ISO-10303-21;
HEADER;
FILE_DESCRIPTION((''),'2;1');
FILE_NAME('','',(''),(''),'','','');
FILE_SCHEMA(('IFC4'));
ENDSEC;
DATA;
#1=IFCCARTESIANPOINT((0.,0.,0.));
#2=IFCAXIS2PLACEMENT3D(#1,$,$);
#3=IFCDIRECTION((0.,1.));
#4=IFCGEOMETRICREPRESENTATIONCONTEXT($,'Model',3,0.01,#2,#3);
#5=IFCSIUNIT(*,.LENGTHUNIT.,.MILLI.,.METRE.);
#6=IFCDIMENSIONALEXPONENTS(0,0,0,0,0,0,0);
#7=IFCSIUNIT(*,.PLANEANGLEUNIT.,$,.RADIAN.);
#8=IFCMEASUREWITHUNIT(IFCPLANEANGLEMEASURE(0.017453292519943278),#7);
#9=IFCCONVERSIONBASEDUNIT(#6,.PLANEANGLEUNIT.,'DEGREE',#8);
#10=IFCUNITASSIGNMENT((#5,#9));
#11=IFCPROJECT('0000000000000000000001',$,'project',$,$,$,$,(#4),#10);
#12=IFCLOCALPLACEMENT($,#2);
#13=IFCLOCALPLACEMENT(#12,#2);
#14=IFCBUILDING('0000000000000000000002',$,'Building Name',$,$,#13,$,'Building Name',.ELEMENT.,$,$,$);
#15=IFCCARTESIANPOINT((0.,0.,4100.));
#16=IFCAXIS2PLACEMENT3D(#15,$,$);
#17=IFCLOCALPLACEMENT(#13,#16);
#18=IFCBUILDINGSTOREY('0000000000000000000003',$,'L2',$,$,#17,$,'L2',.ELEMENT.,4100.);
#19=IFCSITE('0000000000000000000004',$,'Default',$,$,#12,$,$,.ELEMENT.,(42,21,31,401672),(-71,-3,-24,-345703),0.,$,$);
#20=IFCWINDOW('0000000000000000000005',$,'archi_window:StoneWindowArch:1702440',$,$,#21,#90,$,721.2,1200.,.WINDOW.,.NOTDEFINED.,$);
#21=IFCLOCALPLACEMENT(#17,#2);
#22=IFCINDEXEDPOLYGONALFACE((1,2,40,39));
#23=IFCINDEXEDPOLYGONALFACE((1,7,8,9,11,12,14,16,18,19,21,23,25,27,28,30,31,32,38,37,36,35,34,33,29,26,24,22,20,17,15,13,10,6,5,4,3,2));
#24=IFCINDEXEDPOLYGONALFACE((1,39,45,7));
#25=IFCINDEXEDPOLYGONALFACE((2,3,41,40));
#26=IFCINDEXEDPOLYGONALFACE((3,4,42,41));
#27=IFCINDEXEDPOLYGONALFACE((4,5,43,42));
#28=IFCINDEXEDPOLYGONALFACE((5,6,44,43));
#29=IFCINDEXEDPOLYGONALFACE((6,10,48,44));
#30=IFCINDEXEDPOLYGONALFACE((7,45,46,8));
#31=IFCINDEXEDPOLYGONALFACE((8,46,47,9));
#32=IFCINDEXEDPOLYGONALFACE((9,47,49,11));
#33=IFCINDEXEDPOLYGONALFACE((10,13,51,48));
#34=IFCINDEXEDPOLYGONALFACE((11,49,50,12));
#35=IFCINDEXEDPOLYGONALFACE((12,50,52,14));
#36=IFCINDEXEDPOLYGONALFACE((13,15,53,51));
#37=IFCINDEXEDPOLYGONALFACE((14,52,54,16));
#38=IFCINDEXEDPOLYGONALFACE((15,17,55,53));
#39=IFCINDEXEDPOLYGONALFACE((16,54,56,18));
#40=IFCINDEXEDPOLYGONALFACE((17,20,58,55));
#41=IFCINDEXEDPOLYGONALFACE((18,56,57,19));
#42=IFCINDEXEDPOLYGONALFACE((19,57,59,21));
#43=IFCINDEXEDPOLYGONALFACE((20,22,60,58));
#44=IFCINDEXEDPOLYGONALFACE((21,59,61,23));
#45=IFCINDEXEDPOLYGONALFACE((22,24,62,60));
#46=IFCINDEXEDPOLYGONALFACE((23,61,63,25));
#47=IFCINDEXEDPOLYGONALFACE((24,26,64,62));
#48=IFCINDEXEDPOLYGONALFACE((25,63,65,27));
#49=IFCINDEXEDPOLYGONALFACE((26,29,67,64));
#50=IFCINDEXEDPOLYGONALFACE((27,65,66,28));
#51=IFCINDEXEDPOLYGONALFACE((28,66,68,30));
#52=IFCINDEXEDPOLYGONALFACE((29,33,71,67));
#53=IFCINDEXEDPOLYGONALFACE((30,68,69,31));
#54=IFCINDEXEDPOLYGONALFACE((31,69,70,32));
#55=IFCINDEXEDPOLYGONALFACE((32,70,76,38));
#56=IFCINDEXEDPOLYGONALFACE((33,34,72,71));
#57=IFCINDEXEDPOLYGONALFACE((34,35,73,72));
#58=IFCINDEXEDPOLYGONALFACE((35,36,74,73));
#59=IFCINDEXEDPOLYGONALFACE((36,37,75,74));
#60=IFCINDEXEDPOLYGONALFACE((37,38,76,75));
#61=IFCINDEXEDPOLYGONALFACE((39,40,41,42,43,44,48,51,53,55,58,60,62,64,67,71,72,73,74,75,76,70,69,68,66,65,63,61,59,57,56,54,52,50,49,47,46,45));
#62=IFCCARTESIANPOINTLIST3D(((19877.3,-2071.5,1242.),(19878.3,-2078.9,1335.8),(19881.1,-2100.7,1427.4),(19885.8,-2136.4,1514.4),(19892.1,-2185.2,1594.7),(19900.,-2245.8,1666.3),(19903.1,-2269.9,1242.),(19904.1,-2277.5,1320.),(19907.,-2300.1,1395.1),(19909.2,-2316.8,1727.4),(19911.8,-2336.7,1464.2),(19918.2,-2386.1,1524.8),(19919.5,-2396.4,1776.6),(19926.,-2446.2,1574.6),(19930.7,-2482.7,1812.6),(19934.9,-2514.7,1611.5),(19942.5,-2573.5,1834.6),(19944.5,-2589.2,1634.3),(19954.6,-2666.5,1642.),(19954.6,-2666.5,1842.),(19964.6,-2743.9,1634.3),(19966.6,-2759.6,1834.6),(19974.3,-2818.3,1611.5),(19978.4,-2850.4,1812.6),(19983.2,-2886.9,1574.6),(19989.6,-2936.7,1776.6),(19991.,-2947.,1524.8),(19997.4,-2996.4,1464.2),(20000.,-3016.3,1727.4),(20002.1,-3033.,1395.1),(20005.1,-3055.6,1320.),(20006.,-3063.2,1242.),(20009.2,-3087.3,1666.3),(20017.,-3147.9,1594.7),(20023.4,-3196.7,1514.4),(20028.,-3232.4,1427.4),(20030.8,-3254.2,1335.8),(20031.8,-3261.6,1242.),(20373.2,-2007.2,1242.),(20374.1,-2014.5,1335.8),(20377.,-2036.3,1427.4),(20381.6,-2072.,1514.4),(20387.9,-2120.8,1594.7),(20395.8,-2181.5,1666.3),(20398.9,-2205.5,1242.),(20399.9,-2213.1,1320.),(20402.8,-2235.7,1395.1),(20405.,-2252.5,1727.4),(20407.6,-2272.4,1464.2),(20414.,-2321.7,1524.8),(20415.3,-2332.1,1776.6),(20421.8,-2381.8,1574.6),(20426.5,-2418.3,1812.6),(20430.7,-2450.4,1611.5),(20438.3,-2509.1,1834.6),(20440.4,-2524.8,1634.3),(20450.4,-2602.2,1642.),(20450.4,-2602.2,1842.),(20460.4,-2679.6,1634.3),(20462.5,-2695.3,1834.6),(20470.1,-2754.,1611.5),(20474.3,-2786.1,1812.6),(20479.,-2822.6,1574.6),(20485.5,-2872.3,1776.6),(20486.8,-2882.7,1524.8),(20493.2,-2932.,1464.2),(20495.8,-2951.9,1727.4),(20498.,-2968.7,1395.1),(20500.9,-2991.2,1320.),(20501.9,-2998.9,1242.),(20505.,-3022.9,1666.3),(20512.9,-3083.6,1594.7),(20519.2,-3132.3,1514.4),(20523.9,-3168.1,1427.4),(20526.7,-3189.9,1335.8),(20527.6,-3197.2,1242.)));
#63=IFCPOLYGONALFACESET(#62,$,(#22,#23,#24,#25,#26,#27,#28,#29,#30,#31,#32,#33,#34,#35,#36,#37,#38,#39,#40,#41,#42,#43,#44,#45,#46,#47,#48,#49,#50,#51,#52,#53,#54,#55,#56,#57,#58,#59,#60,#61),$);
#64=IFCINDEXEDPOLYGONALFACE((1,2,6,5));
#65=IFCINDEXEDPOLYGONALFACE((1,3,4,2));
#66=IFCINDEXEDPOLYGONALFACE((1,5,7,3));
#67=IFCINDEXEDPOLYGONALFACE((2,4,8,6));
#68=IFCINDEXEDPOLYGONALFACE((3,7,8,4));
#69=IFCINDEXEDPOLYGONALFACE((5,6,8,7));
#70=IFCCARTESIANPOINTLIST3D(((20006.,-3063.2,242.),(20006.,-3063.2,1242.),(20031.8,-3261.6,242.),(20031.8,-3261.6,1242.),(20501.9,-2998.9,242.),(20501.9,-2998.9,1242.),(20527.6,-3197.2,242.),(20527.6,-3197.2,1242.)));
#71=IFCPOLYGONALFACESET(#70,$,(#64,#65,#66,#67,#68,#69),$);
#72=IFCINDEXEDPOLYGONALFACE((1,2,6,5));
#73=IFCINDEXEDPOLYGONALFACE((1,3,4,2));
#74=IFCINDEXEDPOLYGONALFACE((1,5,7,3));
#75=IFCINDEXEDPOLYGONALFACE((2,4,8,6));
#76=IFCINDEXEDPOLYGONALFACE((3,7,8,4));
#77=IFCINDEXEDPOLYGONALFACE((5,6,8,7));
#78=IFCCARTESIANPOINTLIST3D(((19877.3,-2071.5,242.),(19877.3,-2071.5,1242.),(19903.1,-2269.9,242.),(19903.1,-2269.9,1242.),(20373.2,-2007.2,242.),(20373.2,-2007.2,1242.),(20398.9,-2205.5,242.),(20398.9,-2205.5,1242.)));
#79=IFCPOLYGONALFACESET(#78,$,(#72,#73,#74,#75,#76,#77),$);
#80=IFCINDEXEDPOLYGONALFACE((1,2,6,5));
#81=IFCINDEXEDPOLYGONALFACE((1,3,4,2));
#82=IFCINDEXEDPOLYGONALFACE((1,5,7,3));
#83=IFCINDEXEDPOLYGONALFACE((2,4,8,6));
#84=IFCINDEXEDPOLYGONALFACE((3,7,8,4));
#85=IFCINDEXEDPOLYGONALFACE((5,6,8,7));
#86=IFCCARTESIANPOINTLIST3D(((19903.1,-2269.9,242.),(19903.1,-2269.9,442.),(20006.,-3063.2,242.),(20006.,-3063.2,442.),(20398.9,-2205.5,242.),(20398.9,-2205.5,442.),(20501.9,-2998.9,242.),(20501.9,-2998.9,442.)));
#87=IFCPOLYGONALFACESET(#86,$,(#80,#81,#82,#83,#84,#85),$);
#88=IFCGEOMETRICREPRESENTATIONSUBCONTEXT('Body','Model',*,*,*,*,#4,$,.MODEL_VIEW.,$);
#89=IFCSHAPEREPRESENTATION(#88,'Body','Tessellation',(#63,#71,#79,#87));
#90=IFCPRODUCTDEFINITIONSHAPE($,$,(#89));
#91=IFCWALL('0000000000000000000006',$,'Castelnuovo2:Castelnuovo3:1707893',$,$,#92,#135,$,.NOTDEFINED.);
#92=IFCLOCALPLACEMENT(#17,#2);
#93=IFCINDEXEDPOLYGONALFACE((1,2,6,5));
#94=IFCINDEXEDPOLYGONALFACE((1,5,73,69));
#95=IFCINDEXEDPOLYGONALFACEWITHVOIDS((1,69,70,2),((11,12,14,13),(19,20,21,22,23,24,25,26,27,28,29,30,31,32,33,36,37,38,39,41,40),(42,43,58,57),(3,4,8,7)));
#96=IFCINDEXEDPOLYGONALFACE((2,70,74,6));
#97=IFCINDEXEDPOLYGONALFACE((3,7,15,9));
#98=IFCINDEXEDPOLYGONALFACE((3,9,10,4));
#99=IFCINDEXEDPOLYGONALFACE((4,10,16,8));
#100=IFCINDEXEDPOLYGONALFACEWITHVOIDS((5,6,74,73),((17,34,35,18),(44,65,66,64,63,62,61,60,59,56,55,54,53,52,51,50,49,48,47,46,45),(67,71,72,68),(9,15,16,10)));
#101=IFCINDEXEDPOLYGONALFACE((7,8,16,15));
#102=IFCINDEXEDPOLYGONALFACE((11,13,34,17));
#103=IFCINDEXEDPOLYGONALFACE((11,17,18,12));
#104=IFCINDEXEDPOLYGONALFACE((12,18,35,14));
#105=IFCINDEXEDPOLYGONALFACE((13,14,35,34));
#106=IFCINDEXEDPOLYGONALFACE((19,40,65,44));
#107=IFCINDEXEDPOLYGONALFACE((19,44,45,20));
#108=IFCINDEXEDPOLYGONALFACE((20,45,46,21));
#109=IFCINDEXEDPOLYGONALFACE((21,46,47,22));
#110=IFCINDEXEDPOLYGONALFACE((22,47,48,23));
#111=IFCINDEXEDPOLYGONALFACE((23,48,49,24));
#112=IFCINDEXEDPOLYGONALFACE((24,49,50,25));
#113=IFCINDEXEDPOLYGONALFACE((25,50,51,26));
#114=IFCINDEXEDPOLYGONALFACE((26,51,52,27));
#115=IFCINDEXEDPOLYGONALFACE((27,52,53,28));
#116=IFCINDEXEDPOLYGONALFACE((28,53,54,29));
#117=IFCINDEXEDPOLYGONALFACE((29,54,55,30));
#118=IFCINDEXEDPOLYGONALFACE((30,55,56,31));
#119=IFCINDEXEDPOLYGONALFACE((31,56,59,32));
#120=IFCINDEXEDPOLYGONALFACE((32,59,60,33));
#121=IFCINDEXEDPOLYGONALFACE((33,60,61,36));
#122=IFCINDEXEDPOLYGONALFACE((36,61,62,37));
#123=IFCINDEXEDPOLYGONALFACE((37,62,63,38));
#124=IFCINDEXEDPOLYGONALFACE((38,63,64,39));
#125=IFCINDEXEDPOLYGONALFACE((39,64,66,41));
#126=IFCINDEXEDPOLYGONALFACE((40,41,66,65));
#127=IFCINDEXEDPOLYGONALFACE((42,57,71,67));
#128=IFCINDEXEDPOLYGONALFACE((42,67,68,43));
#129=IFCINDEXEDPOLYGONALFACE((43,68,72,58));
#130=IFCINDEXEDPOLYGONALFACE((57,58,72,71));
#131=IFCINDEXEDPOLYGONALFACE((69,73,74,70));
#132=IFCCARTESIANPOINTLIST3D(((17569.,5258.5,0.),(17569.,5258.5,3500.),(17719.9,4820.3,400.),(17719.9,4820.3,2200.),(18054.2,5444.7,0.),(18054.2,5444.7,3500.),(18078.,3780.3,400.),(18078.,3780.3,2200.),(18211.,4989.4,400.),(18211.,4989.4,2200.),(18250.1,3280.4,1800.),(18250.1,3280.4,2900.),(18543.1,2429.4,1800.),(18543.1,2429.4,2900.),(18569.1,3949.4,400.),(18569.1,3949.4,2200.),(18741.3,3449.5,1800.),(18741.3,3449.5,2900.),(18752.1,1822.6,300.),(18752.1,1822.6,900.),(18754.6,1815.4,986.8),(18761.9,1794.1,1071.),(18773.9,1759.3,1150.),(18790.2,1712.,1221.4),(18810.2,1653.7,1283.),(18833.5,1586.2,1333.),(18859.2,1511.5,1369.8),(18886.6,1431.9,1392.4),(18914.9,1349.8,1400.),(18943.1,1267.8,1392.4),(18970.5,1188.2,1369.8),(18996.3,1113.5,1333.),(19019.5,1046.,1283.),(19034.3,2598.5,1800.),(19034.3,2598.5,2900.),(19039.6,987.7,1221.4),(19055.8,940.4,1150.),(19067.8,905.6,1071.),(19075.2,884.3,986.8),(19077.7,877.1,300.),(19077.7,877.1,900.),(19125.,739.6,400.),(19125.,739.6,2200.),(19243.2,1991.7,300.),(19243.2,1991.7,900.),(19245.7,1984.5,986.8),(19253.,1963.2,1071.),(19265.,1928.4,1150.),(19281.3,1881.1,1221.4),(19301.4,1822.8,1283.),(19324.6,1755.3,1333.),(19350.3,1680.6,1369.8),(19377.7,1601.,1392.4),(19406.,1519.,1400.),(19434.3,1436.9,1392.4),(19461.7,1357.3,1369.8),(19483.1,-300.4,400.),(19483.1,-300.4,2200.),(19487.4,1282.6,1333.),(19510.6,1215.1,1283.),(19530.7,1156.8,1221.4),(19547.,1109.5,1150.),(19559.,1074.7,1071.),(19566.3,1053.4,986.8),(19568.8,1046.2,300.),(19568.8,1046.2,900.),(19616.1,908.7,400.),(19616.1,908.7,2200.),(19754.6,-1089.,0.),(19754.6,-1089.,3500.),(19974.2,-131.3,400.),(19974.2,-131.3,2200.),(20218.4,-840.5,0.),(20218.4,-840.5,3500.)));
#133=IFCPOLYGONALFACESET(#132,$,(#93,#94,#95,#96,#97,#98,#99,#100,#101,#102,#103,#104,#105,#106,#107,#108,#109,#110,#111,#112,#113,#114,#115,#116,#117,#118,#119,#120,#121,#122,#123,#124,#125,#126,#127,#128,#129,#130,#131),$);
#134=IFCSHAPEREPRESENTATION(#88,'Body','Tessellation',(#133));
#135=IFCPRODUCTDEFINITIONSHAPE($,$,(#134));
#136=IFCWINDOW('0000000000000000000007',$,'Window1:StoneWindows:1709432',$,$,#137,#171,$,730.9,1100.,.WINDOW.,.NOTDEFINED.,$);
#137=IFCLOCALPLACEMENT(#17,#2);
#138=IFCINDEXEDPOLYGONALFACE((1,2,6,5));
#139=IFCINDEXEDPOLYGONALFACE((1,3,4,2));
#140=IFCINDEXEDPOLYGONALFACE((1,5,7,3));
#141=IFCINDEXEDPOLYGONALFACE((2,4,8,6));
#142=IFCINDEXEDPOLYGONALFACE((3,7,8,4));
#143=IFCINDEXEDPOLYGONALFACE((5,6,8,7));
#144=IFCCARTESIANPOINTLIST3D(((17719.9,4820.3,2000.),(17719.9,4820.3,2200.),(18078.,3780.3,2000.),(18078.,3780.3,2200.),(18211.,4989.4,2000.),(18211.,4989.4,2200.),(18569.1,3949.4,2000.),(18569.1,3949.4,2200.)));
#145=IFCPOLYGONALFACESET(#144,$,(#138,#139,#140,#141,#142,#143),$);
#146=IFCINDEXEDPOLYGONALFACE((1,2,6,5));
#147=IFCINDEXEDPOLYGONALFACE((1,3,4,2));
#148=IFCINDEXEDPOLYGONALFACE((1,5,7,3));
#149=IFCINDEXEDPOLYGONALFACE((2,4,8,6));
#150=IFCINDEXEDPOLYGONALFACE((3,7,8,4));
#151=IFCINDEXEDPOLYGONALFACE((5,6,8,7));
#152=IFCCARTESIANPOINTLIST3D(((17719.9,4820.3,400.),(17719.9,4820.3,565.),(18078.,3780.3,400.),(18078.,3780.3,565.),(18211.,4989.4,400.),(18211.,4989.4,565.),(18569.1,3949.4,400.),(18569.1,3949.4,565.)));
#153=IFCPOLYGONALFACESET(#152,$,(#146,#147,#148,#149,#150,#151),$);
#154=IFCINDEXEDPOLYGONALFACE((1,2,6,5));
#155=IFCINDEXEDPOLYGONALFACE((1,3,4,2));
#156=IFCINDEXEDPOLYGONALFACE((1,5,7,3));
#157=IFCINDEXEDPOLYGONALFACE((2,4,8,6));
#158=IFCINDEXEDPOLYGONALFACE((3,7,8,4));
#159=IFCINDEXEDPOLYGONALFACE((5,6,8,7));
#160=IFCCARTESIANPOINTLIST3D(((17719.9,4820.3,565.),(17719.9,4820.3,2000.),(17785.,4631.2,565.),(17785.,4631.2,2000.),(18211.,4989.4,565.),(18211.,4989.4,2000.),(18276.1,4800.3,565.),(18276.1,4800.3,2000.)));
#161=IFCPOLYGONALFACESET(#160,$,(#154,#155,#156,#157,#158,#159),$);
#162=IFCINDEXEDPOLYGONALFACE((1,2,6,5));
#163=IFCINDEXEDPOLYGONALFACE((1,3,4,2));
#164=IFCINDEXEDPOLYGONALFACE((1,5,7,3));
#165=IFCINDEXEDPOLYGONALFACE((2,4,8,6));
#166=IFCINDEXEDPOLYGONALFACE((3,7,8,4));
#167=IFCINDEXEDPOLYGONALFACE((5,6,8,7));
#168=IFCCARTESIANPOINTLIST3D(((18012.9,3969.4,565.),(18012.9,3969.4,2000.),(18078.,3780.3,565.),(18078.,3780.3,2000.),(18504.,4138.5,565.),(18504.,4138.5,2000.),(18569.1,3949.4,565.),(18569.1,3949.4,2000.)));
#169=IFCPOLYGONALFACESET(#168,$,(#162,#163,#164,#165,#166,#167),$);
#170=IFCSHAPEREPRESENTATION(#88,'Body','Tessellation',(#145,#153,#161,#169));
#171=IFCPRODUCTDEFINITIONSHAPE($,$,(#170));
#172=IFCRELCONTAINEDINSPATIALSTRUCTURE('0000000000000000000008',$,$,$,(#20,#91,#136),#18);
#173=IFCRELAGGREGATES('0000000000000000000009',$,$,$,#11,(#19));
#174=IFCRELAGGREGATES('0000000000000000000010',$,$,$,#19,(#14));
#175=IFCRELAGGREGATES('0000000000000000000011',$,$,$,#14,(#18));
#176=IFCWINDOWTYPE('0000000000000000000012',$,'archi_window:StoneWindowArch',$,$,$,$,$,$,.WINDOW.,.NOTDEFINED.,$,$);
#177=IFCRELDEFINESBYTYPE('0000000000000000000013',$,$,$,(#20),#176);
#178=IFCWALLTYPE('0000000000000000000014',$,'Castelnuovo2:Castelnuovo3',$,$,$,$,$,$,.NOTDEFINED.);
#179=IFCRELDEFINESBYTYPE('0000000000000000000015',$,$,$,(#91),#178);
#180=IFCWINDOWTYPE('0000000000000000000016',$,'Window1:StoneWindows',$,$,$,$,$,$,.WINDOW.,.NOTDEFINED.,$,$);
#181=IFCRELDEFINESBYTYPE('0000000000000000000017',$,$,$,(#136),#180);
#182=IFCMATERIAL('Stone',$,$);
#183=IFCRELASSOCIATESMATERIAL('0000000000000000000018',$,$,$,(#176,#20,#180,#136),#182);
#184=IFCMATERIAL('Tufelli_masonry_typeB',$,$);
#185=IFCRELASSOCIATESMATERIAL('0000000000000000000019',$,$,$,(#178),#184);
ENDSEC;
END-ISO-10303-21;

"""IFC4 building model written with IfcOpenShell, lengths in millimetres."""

from ifc_helpers import new_model, entity, si_unit, converted_unit, direction, frame, origin, place, context, subcontext, project, spatial, line, arc, indexed_curve, outline, extrude, source, transform, mapped, material, type_object, type_shapes, element, save


model = new_model("IFC4")

# Units and contexts
model_context = context("Model", 3, precision=0.01, world=origin(), true_north=direction((0.0, 1.0)))
body_context = subcontext(model_context, "Body", "Model", "MODEL_VIEW")
ifc_project = project(units=[si_unit("LENGTHUNIT", "METRE", prefix="MILLI"), converted_unit("PLANEANGLEUNIT", "DEGREE", entity("IfcPlaneAngleMeasure", 0.017453292519943278), si_unit("PLANEANGLEUNIT", "RADIAN"), dimensions=[0, 0, 0, 0, 0, 0, 0])], contexts=[model_context])

# Site, building, storey
site_placement = place(None, origin())
site = spatial("IfcSite", under=ifc_project, at=site_placement, Name="Default", CompositionType="ELEMENT", RefLatitude=(42, 21, 31, 401672), RefLongitude=(-71, -3, -24, -345703), RefElevation=0.0)
building_placement = place(site_placement, origin())
building = spatial("IfcBuilding", under=site, at=building_placement, Name="Building Name", LongName="Building Name", CompositionType="ELEMENT")
storey_placement = place(building_placement, frame((0.0, 0.0, 4100.0)))
storey = spatial("IfcBuildingStorey", under=building, at=storey_placement, Name="L2", LongName="L2", CompositionType="ELEMENT", Elevation=4100.0)

# Shared definitions
ifc_material_1 = material(Name="Tufelli_masonry_typeB")

# Window
ifc_material_2 = material(Name="Stone")
window_type_1 = type_object("IfcWindowType", Name="archi_window:StoneWindowArch", PartitioningType="NOTDEFINED", PredefinedType="WINDOW", material=ifc_material_2)
shared_shape_1 = source(origin(), body_context, "Body", "SweptSolid", [
    extrude(outline(indexed_curve([(400.0, 0.0), (600.0, 0.0), (0.0, 600.0), (-600.0, 0.0), (-400.0, 0.0), (0.0, 400.0)], segments=[line(1, 2), arc(2, 3, 4), line(4, 5), arc(5, 6, 1)], self_intersect=False)), frame((0.0, -250.0, 1800.0), z_axis=(0.0, -1.0, 0.0), x_axis=(1.0, 0.0, 0.0)), (0.0, 0.0, -1.0), 500.0),
    extrude(outline(indexed_curve([(-250.0, -100.0), (250.0, -100.0), (250.0, 100.0), (-250.0, 100.0), (-250.0, -100.0)], self_intersect=False)), frame((500.0, 0.0, 800.0), z_axis=(0.0, 0.0, 1.0), x_axis=(0.0, 1.0, 0.0)), (0.0, 0.0, 1.0), 1000.0),
    extrude(outline(indexed_curve([(-250.0, -100.0), (250.0, -100.0), (250.0, 100.0), (-250.0, 100.0), (-250.0, -100.0)], self_intersect=False)), frame((-500.0, 0.0, 800.0), z_axis=(0.0, 0.0, 1.0), x_axis=(0.0, 1.0, 0.0)), (0.0, 0.0, 1.0), 1000.0),
    extrude(outline(indexed_curve([(-250.0, -400.0), (250.0, -400.0), (250.0, 400.0), (-250.0, 400.0), (-250.0, -400.0)], self_intersect=False)), frame((0.0, 0.0, 800.0), z_axis=(0.0, 0.0, 1.0), x_axis=(0.0, 1.0, 0.0)), (0.0, 0.0, 1.0), 200.0),
])
type_shapes(window_type_1, [shared_shape_1])
window_1_placement = place(storey_placement, frame((20202.5, -2634.4, -558.0), z_axis=(0.0, 0.0, 1.0), x_axis=(0.128709, -0.991682, 0.0)))
element("IfcWindow", 1, at=window_1_placement, inside=storey, type_object=window_type_1, material=ifc_material_2, Name="archi_window:StoneWindowArch:1702440", OverallHeight=721.2, OverallWidth=1200.0, PartitioningType="NOTDEFINED", PredefinedType="WINDOW", context=body_context, shape_type="MappedRepresentation", body=[
    mapped(shared_shape_1, transform((0.0, 0.0, 0.0), scale=1.0)),
])

# Wall, openings
wall_type_1 = type_object("IfcWallType", Name="Castelnuovo2:Castelnuovo3", PredefinedType="NOTDEFINED", material=ifc_material_1)
wall_1_placement = place(storey_placement, frame((17569.0, -1089.0, 0.0), z_axis=(0.0, 0.0, 1.0), x_axis=(0.0, 1.0, 0.0)))
wall_1 = element("IfcWall", 2, at=wall_1_placement, inside=storey, type_object=wall_type_1, Name="Castelnuovo2:Castelnuovo3:1707893", PredefinedType="NOTDEFINED", context=body_context, shape_type="SweptSolid", body=[
    extrude(outline(indexed_curve([(-376.4, -3338.1), (143.3, -3338.1), (377.6, 3371.0), (-144.5, 3305.2), (-376.4, -3338.1)], self_intersect=False)), frame((3282.4, -1330.1, 0.0), z_axis=(0.0, 0.0, 1.0), x_axis=(-0.358368, 0.93358, 0.0)), (0.0, 0.0, 1.0), 3500.0),
])
opening_1_placement = place(wall_1_placement, origin())
element("IfcOpeningElement", 3, at=opening_1_placement, cuts=wall_1, PredefinedType="OPENING", context=body_context, shape_type="SweptSolid", body=[
    extrude(outline(indexed_curve([(-900.0, -550.0), (900.0, -550.0), (900.0, 550.0), (-900.0, 550.0), (-900.0, -550.0)], self_intersect=False)), frame((5382.6, -310.3, 1300.0), z_axis=(0.325568, -0.945519, 0.0), x_axis=(0.0, 0.0, 1.0)), (0.0, 0.0, 1.0), 612.9),
])
opening_2_placement = place(wall_1_placement, origin())
element("IfcOpeningElement", 4, at=opening_2_placement, cuts=wall_1, PredefinedType="OPENING", context=body_context, shape_type="SweptSolid", body=[
    extrude(outline(indexed_curve([(-900.0, -550.0), (900.0, -550.0), (900.0, 550.0), (-900.0, 550.0), (-900.0, -550.0)], self_intersect=False)), frame((1301.9, -1715.4, 1300.0), z_axis=(0.325568, -0.945519, 0.0), x_axis=(0.0, 0.0, 1.0)), (0.0, 0.0, 1.0), 612.9),
])
opening_3_placement = place(wall_1_placement, origin())
element("IfcOpeningElement", 5, at=opening_3_placement, cuts=wall_1, PredefinedType="OPENING", context=body_context, shape_type="SweptSolid", body=[
    extrude(outline(indexed_curve([(-550.0, -450.0), (550.0, -450.0), (550.0, 450.0), (-550.0, 450.0), (-550.0, -450.0)], self_intersect=False)), frame((3937.2, -808.0, 2350.0), z_axis=(0.325568, -0.945519, 0.0), x_axis=(0.0, 0.0, 1.0)), (0.0, 0.0, 1.0), 612.9),
])
opening_4_placement = place(wall_1_placement, origin())
element("IfcOpeningElement", 6, at=opening_4_placement, cuts=wall_1, PredefinedType="OPENING", context=body_context, shape_type="SweptSolid", body=[
    extrude(outline(indexed_curve([(-300.0, -500.0), (300.0, -500.0), (800.0, 0.0), (300.0, 500.0), (-300.0, 500.0)], segments=[line(1, 2), arc(2, 3, 4), line(4, 5, 1)], self_intersect=False)), frame((2432.1, -1326.2, 600.0), z_axis=(0.325568, -0.945519, 0.0), x_axis=(0.0, 0.0, 1.0)), (0.0, 0.0, 1.0), 612.9),
])

# Window
window_type_2 = type_object("IfcWindowType", Name="Window1:StoneWindows", PartitioningType="NOTDEFINED", PredefinedType="WINDOW", material=ifc_material_2)
shared_shape_2 = source(origin(), body_context, "Body", "SweptSolid", [
    extrude(outline(indexed_curve([(-259.7, -550.0), (259.7, -550.0), (259.7, 550.0), (-259.7, 550.0), (-259.7, -550.0)], self_intersect=False)), frame((0.0, 0.0, 2400.0), z_axis=(0.0, 0.0, 1.0), x_axis=(0.0, 1.0, 0.0)), (0.0, 0.0, 1.0), 200.0),
    extrude(outline(indexed_curve([(-259.7, -550.0), (259.7, -550.0), (259.7, 550.0), (-259.7, 550.0), (-259.7, -550.0)], self_intersect=False)), frame((0.0, 0.0, 800.0), z_axis=(0.0, 0.0, 1.0), x_axis=(0.0, 1.0, 0.0)), (0.0, 0.0, 1.0), 165.0),
    extrude(outline(indexed_curve([(-259.7, -100.0), (259.7, -100.0), (259.7, 100.0), (-259.7, 100.0), (-259.7, -100.0)], self_intersect=False)), frame((-450.0, 0.0, 965.0), z_axis=(0.0, 0.0, 1.0), x_axis=(0.0, 1.0, 0.0)), (0.0, 0.0, 1.0), 1435.0),
    extrude(outline(indexed_curve([(-259.7, -100.0), (259.7, -100.0), (259.7, 100.0), (-259.7, 100.0), (-259.7, -100.0)], self_intersect=False)), frame((450.0, 0.0, 965.0), z_axis=(0.0, 0.0, 1.0), x_axis=(0.0, 1.0, 0.0)), (0.0, 0.0, 1.0), 1435.0),
])
type_shapes(window_type_2, [shared_shape_2])
for number, where, z_axis, x_axis, name in (
    (7, (18144.5, 4384.8, -400.0), (0.0, 0.0, 1.0), (0.325568, -0.945519, 0.0), "Window1:StoneWindows:1709432"),
):
    element("IfcWindow", number, at=place(storey_placement, frame(where, z_axis=z_axis, x_axis=x_axis)), inside=storey, type_object=window_type_2, material=ifc_material_2, Name=name, OverallHeight=730.9, OverallWidth=1100.0, PartitioningType="NOTDEFINED", PredefinedType="WINDOW", context=body_context, shape_type="MappedRepresentation", body=[
        mapped(shared_shape_2, transform((0.0, 0.0, 0.0), scale=1.0)),
    ])

save(model, "model.ifc")
